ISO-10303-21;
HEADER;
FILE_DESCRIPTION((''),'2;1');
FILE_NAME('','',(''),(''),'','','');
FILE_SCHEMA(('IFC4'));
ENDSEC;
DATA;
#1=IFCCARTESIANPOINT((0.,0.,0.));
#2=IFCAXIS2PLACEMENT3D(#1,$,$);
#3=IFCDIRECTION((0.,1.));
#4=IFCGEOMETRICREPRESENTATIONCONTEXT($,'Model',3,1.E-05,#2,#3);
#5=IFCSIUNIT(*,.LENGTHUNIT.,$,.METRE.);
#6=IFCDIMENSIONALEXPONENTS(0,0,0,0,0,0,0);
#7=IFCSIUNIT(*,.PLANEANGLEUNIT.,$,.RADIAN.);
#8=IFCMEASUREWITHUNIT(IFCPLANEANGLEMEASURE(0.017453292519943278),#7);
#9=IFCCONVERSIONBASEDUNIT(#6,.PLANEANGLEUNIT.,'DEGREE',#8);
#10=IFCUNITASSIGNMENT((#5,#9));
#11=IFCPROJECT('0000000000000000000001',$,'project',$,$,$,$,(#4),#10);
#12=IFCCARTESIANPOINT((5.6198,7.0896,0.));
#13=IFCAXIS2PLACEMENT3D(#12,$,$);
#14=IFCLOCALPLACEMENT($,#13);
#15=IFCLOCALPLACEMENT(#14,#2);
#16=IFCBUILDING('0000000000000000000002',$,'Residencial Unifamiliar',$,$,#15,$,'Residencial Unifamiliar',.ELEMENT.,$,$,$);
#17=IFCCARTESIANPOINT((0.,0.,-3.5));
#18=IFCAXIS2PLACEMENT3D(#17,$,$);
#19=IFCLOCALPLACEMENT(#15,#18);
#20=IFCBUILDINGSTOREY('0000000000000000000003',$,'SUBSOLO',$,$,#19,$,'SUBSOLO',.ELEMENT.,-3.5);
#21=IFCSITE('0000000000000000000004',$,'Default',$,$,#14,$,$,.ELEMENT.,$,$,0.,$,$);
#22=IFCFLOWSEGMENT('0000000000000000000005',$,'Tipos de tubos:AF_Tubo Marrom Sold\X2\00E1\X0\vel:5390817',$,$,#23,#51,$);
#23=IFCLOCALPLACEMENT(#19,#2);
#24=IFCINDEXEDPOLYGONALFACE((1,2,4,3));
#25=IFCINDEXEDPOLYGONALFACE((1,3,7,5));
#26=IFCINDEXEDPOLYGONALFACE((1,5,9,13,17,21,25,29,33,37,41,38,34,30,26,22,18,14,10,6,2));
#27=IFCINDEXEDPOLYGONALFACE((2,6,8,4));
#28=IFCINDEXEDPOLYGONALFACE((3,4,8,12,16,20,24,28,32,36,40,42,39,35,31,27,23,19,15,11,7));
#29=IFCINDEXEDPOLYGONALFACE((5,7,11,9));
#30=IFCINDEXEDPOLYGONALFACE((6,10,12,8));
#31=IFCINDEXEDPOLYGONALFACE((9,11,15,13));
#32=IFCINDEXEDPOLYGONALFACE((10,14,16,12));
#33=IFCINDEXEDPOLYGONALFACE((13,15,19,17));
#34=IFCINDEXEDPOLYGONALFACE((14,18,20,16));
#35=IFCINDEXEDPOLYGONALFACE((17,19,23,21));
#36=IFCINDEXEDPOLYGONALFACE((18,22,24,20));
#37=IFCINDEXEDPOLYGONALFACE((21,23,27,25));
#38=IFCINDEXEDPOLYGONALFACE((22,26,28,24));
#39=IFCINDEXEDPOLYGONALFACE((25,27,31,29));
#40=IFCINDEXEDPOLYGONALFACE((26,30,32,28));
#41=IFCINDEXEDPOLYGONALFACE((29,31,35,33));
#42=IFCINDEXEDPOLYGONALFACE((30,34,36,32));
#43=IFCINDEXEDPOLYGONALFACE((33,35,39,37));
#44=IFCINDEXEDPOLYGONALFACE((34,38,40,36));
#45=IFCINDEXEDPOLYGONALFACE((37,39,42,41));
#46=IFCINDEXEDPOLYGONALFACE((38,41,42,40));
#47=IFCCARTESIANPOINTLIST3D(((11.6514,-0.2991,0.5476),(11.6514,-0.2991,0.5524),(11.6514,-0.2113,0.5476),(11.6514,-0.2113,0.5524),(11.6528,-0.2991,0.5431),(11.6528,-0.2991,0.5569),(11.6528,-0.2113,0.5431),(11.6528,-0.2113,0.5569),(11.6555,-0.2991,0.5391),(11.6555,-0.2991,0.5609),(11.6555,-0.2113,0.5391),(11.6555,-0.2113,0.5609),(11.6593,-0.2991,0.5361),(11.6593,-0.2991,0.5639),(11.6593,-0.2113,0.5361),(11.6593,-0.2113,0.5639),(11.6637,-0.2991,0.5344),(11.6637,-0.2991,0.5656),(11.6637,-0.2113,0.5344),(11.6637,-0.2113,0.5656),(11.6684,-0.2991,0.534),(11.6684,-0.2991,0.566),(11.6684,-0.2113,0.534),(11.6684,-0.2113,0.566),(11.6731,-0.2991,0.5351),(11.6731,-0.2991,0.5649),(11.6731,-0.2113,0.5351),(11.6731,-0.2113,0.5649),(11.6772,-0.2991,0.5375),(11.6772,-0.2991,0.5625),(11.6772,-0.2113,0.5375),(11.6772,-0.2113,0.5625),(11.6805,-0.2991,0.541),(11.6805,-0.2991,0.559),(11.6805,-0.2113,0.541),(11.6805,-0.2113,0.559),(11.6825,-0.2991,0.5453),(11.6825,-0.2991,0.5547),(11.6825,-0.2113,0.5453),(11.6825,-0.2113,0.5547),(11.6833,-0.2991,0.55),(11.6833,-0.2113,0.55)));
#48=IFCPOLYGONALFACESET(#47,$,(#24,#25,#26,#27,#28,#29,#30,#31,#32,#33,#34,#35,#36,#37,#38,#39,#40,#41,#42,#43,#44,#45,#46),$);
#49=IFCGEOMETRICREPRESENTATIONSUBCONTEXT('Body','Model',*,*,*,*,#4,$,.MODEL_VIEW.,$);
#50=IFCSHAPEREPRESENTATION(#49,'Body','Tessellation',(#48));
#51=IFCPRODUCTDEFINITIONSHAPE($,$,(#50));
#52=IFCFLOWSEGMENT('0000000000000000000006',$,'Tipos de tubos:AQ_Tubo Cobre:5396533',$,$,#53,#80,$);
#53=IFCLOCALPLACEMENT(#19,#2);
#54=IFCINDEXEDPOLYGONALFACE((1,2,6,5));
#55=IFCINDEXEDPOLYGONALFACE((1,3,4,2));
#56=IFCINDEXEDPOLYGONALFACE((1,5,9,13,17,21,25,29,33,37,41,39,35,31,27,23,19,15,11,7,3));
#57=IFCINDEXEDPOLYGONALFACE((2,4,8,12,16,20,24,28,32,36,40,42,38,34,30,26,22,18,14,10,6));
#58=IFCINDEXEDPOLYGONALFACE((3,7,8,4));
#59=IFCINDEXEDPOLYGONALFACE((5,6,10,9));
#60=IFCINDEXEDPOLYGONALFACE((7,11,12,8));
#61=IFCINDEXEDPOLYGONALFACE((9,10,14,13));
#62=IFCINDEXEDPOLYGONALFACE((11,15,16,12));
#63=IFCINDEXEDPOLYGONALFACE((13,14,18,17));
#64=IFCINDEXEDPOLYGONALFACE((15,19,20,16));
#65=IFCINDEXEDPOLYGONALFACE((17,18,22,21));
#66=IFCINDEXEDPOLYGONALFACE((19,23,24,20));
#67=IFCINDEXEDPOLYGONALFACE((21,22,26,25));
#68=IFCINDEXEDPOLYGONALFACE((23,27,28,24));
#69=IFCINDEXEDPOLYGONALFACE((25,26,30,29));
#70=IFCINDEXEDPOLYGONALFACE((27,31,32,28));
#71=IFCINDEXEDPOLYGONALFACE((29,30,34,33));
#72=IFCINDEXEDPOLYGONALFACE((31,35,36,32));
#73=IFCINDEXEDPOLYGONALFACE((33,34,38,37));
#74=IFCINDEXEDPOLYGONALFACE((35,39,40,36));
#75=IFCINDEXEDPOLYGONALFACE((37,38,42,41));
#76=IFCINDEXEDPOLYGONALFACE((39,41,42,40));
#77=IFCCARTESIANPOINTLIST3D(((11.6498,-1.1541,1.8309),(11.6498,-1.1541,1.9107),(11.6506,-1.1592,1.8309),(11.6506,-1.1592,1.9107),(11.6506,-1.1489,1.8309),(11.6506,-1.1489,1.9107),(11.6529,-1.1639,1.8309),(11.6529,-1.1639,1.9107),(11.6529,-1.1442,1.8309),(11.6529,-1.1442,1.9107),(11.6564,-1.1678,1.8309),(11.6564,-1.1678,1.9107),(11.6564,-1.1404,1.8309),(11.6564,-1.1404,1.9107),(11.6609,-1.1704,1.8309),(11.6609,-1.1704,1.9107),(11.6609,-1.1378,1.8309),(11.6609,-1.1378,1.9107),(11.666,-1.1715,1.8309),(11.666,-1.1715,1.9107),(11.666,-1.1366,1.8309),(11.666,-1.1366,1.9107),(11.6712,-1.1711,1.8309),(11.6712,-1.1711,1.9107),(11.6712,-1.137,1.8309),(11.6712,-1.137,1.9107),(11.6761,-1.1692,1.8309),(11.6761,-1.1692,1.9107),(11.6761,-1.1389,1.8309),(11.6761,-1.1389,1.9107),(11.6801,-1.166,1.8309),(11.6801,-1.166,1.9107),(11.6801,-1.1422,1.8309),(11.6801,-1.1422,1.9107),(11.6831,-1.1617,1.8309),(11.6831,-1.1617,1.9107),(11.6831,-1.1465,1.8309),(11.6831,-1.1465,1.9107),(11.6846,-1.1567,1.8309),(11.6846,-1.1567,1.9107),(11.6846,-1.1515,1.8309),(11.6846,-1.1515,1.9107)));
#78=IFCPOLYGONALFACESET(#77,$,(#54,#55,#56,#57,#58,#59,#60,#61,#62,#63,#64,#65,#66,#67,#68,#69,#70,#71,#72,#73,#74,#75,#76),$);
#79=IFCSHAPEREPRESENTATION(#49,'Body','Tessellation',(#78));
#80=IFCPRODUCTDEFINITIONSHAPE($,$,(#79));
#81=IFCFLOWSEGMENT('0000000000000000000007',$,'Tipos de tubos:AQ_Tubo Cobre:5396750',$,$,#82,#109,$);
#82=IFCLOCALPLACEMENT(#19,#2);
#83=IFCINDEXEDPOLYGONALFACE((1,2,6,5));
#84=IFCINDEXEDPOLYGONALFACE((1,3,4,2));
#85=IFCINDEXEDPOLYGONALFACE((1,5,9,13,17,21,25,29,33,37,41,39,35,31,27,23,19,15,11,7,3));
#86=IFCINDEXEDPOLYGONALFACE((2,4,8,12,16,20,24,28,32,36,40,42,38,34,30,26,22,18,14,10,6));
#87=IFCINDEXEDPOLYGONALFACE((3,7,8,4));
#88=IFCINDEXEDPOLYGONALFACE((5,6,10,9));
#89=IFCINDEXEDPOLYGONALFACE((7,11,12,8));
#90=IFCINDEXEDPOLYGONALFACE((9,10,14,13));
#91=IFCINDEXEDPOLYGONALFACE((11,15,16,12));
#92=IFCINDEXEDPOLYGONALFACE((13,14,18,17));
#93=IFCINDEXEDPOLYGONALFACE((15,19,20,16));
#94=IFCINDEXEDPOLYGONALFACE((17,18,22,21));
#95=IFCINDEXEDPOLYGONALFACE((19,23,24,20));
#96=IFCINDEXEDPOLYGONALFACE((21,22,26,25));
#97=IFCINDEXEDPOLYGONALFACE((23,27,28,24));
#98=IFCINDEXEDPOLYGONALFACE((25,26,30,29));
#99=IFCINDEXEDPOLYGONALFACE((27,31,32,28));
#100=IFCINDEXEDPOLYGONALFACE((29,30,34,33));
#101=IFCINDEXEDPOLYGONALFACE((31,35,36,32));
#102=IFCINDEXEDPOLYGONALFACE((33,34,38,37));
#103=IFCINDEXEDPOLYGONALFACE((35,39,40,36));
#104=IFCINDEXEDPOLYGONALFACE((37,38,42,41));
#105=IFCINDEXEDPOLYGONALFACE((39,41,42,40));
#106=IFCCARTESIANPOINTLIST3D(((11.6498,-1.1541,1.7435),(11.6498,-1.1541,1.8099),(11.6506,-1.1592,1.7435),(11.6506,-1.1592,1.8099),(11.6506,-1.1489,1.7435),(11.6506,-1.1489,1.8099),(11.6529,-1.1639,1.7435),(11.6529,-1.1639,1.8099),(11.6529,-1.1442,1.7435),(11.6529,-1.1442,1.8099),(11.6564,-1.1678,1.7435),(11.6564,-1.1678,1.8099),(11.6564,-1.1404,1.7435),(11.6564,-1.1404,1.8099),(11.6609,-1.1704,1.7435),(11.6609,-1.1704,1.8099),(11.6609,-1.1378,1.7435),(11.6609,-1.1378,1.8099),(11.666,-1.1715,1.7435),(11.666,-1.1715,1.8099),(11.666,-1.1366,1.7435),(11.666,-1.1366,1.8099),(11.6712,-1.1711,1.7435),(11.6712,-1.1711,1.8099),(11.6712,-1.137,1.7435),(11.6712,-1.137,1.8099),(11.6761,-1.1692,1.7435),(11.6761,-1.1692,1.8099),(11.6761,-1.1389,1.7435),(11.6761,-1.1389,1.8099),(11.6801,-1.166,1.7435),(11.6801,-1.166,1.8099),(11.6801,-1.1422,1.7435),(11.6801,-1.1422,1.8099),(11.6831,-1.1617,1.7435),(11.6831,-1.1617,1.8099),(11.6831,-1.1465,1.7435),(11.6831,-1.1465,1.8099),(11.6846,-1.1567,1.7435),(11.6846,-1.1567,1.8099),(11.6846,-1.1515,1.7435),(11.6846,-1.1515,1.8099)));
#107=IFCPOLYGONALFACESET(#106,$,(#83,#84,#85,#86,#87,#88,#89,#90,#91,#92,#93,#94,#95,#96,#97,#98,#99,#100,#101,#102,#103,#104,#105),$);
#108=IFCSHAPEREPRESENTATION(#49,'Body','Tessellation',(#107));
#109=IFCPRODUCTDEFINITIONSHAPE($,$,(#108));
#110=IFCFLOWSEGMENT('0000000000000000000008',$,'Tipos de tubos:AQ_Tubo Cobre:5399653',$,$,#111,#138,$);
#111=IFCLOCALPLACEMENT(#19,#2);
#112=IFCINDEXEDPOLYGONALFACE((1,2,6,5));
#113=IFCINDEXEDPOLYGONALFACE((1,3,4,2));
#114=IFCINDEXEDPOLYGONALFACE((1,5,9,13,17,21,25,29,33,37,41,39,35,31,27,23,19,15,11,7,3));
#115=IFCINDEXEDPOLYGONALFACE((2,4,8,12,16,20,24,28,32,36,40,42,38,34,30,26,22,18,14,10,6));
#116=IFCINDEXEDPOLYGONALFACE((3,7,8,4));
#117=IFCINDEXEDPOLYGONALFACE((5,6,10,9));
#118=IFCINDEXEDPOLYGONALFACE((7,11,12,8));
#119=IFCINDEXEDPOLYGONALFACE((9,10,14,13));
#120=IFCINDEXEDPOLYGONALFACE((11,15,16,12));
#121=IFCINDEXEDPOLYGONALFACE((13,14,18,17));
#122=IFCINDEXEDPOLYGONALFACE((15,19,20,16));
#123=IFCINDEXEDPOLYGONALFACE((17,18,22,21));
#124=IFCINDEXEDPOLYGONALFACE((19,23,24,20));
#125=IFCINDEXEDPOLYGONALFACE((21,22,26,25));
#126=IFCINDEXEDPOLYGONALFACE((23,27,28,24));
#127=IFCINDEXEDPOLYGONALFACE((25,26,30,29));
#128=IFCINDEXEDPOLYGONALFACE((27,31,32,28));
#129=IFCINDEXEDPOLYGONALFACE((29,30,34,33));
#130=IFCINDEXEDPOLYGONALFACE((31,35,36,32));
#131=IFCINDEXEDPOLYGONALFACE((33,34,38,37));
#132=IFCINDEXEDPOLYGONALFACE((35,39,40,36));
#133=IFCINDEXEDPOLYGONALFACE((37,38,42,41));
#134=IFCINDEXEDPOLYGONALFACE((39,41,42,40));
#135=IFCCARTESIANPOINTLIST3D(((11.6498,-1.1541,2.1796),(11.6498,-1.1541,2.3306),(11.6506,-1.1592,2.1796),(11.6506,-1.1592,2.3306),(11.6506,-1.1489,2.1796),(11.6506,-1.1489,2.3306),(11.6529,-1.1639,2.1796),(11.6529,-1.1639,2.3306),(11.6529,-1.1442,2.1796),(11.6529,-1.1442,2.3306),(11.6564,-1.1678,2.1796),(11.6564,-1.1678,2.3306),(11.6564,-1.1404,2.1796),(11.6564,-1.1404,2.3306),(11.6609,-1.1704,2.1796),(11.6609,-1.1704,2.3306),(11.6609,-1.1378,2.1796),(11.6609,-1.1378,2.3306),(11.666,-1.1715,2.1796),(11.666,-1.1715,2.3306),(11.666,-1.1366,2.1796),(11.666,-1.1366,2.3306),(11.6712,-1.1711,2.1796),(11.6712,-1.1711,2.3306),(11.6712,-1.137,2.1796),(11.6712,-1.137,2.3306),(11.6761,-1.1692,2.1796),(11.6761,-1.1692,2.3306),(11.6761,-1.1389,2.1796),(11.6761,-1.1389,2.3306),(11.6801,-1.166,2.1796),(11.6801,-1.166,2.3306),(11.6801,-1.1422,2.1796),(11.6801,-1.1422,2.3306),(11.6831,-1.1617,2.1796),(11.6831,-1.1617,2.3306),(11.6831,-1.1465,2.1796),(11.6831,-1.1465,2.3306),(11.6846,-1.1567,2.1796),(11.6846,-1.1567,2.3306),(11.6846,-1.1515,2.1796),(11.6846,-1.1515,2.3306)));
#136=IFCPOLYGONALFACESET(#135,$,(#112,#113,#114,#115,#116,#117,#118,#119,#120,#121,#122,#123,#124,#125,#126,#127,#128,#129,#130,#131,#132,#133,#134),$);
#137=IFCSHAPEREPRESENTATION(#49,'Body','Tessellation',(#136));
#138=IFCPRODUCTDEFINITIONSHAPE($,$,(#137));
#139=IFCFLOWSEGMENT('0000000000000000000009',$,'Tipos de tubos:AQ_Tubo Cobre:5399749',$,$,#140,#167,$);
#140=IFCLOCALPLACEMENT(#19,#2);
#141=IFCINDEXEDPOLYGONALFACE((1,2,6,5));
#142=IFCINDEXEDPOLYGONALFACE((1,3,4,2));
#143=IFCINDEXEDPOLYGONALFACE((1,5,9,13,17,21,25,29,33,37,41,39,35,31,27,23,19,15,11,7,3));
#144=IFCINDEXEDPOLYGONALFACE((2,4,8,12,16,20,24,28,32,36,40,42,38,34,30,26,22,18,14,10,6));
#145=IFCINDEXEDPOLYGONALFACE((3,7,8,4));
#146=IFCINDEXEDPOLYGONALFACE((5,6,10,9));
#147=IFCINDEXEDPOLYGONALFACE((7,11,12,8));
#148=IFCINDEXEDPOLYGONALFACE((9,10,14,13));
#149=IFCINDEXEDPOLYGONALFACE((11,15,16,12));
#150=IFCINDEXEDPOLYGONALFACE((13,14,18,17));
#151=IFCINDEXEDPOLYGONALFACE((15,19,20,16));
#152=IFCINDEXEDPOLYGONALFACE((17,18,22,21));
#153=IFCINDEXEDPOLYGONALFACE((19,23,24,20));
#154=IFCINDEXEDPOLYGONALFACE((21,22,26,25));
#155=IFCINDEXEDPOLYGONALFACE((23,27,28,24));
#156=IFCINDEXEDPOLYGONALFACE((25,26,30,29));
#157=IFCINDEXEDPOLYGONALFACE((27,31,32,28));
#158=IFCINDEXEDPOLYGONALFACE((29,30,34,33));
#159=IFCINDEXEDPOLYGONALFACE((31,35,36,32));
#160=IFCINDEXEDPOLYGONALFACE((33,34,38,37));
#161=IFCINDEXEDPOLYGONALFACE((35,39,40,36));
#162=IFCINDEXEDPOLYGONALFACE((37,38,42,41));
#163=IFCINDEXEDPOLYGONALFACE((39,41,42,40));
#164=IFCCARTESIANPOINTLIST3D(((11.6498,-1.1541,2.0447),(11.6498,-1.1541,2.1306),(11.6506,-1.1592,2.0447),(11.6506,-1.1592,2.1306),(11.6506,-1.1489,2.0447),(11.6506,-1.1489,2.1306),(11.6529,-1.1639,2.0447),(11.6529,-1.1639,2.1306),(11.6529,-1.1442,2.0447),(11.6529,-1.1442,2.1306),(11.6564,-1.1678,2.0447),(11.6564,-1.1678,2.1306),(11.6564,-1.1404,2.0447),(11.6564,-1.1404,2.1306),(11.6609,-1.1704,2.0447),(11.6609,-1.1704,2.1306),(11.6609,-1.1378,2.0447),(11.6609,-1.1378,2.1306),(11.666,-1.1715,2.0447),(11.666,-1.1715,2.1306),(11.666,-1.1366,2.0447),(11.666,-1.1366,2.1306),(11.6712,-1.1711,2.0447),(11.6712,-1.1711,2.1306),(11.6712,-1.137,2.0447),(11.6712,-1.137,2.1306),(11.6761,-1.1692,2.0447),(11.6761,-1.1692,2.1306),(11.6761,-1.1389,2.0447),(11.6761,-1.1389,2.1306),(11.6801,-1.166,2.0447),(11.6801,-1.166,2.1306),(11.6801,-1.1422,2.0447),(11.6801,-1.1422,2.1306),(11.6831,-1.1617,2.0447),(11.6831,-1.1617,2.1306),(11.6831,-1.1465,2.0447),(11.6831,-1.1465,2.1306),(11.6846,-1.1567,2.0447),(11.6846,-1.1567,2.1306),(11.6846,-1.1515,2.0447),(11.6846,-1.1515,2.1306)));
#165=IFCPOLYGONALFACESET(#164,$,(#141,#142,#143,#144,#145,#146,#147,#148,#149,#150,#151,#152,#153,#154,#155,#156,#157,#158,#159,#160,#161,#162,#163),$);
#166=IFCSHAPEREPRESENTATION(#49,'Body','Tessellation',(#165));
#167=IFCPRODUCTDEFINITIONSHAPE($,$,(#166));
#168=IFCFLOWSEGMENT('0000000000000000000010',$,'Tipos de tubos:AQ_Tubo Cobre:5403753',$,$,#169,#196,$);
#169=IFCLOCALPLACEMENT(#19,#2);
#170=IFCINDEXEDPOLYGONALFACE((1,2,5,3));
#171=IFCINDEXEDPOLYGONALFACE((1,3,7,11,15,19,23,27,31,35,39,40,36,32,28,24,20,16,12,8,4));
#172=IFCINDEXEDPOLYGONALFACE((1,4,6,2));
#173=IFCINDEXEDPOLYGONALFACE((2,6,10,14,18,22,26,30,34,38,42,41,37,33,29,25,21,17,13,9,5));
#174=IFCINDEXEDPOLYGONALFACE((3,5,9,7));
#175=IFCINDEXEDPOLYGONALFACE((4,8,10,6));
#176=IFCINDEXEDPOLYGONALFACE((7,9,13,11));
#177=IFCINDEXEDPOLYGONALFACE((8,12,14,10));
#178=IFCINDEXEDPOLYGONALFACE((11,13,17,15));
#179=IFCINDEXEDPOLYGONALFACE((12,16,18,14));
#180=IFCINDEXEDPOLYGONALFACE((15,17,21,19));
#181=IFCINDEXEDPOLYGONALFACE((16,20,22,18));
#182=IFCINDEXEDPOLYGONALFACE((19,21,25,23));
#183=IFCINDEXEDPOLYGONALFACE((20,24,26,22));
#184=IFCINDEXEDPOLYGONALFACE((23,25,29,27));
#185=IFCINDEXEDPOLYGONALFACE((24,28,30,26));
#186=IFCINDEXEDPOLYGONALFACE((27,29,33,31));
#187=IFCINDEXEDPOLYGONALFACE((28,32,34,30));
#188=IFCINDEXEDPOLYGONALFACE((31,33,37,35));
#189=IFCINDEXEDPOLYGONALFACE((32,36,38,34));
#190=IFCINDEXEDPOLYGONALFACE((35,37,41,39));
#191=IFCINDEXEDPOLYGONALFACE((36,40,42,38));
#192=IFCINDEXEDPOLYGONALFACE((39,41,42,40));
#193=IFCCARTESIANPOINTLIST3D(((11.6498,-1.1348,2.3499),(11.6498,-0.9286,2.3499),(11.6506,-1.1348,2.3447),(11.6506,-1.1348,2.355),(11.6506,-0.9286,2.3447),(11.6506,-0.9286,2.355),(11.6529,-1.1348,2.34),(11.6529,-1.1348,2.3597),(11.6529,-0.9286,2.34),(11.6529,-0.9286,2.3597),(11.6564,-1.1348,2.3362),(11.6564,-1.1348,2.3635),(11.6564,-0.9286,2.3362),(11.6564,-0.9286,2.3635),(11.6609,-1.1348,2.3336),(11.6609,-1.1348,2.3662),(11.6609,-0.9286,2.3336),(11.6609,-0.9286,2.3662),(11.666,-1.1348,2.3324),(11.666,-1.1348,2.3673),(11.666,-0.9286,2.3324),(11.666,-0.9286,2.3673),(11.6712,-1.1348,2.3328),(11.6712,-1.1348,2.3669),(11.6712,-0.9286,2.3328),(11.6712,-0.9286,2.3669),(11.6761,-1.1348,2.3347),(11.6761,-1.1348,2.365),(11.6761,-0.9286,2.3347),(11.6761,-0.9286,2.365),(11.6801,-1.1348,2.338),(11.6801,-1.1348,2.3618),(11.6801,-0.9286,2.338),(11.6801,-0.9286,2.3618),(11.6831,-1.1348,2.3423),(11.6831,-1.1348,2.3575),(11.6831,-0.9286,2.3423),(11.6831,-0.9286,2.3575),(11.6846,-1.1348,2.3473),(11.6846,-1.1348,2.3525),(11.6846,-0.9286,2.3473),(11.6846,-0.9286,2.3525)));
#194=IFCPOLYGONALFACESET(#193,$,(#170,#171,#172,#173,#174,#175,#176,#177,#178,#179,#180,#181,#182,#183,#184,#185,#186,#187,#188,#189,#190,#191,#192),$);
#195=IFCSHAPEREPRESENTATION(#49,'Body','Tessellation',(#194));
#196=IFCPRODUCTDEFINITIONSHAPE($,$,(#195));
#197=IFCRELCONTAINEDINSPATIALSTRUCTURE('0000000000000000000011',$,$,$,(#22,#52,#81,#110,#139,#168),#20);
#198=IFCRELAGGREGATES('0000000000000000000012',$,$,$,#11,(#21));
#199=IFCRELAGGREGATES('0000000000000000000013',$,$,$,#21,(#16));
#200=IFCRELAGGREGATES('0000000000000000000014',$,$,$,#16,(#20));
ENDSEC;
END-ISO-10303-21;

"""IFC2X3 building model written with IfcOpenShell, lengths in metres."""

from ifc_helpers import new_model, entity, si_unit, converted_unit, direction, frame, frame_2d, origin, origin_2d_with_axis, place, context, subcontext, project, spatial, circle, extrude, element, save


model = new_model("IFC2X3")

# Units and contexts
model_context = context("Model", 3, precision=1e-05, world=origin(), true_north=direction((0.0, 1.0)))
body_context = subcontext(model_context, "Body", "Model", "MODEL_VIEW")
ifc_project = project(units=[si_unit("LENGTHUNIT", "METRE"), converted_unit("PLANEANGLEUNIT", "DEGREE", entity("IfcPlaneAngleMeasure", 0.017453292519943278), si_unit("PLANEANGLEUNIT", "RADIAN"), dimensions=[0, 0, 0, 0, 0, 0, 0])], contexts=[model_context])

# Site, building, storey
site_placement = place(None, frame((5.6198, 7.0896, 0.0)))
site = spatial("IfcSite", under=ifc_project, at=site_placement, Name="Default", CompositionType="ELEMENT", RefElevation=0.0)
building_placement = place(site_placement, origin())
building = spatial("IfcBuilding", under=site, at=building_placement, Name="Residencial Unifamiliar", LongName="Residencial Unifamiliar", CompositionType="ELEMENT")
storey_placement = place(building_placement, frame((0.0, 0.0, -3.5)))
storey = spatial("IfcBuildingStorey", under=building, at=storey_placement, Name="SUBSOLO", LongName="SUBSOLO", CompositionType="ELEMENT", Elevation=-3.5)

# Flow segments
flow_segment_1_placement = place(storey_placement, origin())
element("IfcFlowSegment", 1, at=flow_segment_1_placement, inside=storey, Name="Tipos de tubos:AF_Tubo Marrom Soldável:5390817", context=body_context, shape_type="SweptSolid", body=[
    extrude(circle(Radius=0.016, at=frame_2d((0.0, 0.0), x_axis=(1.0, 0.0))), frame((11.6673, -0.2991, 0.55), z_axis=(0.0, 1.0, 0.0), x_axis=(1.0, 0.0, 0.0)), (0.0, 0.0, 1.0), 0.0878),
])
flow_segment_2_placement = place(storey_placement, origin())
element("IfcFlowSegment", 2, at=flow_segment_2_placement, inside=storey, Name="Tipos de tubos:AQ_Tubo Cobre:5396533", context=body_context, shape_type="SweptSolid", body=[
    extrude(circle(Radius=0.0175, at=frame_2d((0.0, 0.0), x_axis=(1.0, 0.0))), frame((11.6673, -1.1541, 1.8309), z_axis=(0.0, 0.0, 1.0), x_axis=(-1.0, 0.0, 0.0)), (0.0, 0.0, 1.0), 0.0797),
])
flow_segment_3_placement = place(storey_placement, origin())
element("IfcFlowSegment", 3, at=flow_segment_3_placement, inside=storey, Name="Tipos de tubos:AQ_Tubo Cobre:5396750", context=body_context, shape_type="SweptSolid", body=[
    extrude(circle(Radius=0.0175, at=origin_2d_with_axis()), frame((11.6673, -1.1541, 1.7435), z_axis=(0.0, 0.0, 1.0), x_axis=(-1.0, 0.0, 0.0)), (0.0, 0.0, 1.0), 0.0665),
])
flow_segment_4_placement = place(storey_placement, origin())
element("IfcFlowSegment", 4, at=flow_segment_4_placement, inside=storey, Name="Tipos de tubos:AQ_Tubo Cobre:5399653", context=body_context, shape_type="SweptSolid", body=[
    extrude(circle(Radius=0.0175, at=origin_2d_with_axis()), frame((11.6673, -1.1541, 2.1796), z_axis=(0.0, 0.0, 1.0), x_axis=(-1.0, 0.0, 0.0)), (0.0, 0.0, 1.0), 0.1511),
])
flow_segment_5_placement = place(storey_placement, origin())
element("IfcFlowSegment", 5, at=flow_segment_5_placement, inside=storey, Name="Tipos de tubos:AQ_Tubo Cobre:5399749", context=body_context, shape_type="SweptSolid", body=[
    extrude(circle(Radius=0.0175, at=origin_2d_with_axis()), frame((11.6673, -1.1541, 2.0447), z_axis=(0.0, 0.0, 1.0), x_axis=(-1.0, 0.0, 0.0)), (0.0, 0.0, 1.0), 0.0859),
])
flow_segment_6_placement = place(storey_placement, origin())
element("IfcFlowSegment", 6, at=flow_segment_6_placement, inside=storey, Name="Tipos de tubos:AQ_Tubo Cobre:5403753", context=body_context, shape_type="SweptSolid", body=[
    extrude(circle(Radius=0.0175, at=frame_2d((0.0, 0.0), x_axis=(1.0, 0.0))), frame((11.6673, -1.1348, 2.3499), z_axis=(0.0, 1.0, 0.0), x_axis=(-1.0, 0.0, 0.0)), (0.0, 0.0, 1.0), 0.2063),
])

save(model, "model.ifc")
